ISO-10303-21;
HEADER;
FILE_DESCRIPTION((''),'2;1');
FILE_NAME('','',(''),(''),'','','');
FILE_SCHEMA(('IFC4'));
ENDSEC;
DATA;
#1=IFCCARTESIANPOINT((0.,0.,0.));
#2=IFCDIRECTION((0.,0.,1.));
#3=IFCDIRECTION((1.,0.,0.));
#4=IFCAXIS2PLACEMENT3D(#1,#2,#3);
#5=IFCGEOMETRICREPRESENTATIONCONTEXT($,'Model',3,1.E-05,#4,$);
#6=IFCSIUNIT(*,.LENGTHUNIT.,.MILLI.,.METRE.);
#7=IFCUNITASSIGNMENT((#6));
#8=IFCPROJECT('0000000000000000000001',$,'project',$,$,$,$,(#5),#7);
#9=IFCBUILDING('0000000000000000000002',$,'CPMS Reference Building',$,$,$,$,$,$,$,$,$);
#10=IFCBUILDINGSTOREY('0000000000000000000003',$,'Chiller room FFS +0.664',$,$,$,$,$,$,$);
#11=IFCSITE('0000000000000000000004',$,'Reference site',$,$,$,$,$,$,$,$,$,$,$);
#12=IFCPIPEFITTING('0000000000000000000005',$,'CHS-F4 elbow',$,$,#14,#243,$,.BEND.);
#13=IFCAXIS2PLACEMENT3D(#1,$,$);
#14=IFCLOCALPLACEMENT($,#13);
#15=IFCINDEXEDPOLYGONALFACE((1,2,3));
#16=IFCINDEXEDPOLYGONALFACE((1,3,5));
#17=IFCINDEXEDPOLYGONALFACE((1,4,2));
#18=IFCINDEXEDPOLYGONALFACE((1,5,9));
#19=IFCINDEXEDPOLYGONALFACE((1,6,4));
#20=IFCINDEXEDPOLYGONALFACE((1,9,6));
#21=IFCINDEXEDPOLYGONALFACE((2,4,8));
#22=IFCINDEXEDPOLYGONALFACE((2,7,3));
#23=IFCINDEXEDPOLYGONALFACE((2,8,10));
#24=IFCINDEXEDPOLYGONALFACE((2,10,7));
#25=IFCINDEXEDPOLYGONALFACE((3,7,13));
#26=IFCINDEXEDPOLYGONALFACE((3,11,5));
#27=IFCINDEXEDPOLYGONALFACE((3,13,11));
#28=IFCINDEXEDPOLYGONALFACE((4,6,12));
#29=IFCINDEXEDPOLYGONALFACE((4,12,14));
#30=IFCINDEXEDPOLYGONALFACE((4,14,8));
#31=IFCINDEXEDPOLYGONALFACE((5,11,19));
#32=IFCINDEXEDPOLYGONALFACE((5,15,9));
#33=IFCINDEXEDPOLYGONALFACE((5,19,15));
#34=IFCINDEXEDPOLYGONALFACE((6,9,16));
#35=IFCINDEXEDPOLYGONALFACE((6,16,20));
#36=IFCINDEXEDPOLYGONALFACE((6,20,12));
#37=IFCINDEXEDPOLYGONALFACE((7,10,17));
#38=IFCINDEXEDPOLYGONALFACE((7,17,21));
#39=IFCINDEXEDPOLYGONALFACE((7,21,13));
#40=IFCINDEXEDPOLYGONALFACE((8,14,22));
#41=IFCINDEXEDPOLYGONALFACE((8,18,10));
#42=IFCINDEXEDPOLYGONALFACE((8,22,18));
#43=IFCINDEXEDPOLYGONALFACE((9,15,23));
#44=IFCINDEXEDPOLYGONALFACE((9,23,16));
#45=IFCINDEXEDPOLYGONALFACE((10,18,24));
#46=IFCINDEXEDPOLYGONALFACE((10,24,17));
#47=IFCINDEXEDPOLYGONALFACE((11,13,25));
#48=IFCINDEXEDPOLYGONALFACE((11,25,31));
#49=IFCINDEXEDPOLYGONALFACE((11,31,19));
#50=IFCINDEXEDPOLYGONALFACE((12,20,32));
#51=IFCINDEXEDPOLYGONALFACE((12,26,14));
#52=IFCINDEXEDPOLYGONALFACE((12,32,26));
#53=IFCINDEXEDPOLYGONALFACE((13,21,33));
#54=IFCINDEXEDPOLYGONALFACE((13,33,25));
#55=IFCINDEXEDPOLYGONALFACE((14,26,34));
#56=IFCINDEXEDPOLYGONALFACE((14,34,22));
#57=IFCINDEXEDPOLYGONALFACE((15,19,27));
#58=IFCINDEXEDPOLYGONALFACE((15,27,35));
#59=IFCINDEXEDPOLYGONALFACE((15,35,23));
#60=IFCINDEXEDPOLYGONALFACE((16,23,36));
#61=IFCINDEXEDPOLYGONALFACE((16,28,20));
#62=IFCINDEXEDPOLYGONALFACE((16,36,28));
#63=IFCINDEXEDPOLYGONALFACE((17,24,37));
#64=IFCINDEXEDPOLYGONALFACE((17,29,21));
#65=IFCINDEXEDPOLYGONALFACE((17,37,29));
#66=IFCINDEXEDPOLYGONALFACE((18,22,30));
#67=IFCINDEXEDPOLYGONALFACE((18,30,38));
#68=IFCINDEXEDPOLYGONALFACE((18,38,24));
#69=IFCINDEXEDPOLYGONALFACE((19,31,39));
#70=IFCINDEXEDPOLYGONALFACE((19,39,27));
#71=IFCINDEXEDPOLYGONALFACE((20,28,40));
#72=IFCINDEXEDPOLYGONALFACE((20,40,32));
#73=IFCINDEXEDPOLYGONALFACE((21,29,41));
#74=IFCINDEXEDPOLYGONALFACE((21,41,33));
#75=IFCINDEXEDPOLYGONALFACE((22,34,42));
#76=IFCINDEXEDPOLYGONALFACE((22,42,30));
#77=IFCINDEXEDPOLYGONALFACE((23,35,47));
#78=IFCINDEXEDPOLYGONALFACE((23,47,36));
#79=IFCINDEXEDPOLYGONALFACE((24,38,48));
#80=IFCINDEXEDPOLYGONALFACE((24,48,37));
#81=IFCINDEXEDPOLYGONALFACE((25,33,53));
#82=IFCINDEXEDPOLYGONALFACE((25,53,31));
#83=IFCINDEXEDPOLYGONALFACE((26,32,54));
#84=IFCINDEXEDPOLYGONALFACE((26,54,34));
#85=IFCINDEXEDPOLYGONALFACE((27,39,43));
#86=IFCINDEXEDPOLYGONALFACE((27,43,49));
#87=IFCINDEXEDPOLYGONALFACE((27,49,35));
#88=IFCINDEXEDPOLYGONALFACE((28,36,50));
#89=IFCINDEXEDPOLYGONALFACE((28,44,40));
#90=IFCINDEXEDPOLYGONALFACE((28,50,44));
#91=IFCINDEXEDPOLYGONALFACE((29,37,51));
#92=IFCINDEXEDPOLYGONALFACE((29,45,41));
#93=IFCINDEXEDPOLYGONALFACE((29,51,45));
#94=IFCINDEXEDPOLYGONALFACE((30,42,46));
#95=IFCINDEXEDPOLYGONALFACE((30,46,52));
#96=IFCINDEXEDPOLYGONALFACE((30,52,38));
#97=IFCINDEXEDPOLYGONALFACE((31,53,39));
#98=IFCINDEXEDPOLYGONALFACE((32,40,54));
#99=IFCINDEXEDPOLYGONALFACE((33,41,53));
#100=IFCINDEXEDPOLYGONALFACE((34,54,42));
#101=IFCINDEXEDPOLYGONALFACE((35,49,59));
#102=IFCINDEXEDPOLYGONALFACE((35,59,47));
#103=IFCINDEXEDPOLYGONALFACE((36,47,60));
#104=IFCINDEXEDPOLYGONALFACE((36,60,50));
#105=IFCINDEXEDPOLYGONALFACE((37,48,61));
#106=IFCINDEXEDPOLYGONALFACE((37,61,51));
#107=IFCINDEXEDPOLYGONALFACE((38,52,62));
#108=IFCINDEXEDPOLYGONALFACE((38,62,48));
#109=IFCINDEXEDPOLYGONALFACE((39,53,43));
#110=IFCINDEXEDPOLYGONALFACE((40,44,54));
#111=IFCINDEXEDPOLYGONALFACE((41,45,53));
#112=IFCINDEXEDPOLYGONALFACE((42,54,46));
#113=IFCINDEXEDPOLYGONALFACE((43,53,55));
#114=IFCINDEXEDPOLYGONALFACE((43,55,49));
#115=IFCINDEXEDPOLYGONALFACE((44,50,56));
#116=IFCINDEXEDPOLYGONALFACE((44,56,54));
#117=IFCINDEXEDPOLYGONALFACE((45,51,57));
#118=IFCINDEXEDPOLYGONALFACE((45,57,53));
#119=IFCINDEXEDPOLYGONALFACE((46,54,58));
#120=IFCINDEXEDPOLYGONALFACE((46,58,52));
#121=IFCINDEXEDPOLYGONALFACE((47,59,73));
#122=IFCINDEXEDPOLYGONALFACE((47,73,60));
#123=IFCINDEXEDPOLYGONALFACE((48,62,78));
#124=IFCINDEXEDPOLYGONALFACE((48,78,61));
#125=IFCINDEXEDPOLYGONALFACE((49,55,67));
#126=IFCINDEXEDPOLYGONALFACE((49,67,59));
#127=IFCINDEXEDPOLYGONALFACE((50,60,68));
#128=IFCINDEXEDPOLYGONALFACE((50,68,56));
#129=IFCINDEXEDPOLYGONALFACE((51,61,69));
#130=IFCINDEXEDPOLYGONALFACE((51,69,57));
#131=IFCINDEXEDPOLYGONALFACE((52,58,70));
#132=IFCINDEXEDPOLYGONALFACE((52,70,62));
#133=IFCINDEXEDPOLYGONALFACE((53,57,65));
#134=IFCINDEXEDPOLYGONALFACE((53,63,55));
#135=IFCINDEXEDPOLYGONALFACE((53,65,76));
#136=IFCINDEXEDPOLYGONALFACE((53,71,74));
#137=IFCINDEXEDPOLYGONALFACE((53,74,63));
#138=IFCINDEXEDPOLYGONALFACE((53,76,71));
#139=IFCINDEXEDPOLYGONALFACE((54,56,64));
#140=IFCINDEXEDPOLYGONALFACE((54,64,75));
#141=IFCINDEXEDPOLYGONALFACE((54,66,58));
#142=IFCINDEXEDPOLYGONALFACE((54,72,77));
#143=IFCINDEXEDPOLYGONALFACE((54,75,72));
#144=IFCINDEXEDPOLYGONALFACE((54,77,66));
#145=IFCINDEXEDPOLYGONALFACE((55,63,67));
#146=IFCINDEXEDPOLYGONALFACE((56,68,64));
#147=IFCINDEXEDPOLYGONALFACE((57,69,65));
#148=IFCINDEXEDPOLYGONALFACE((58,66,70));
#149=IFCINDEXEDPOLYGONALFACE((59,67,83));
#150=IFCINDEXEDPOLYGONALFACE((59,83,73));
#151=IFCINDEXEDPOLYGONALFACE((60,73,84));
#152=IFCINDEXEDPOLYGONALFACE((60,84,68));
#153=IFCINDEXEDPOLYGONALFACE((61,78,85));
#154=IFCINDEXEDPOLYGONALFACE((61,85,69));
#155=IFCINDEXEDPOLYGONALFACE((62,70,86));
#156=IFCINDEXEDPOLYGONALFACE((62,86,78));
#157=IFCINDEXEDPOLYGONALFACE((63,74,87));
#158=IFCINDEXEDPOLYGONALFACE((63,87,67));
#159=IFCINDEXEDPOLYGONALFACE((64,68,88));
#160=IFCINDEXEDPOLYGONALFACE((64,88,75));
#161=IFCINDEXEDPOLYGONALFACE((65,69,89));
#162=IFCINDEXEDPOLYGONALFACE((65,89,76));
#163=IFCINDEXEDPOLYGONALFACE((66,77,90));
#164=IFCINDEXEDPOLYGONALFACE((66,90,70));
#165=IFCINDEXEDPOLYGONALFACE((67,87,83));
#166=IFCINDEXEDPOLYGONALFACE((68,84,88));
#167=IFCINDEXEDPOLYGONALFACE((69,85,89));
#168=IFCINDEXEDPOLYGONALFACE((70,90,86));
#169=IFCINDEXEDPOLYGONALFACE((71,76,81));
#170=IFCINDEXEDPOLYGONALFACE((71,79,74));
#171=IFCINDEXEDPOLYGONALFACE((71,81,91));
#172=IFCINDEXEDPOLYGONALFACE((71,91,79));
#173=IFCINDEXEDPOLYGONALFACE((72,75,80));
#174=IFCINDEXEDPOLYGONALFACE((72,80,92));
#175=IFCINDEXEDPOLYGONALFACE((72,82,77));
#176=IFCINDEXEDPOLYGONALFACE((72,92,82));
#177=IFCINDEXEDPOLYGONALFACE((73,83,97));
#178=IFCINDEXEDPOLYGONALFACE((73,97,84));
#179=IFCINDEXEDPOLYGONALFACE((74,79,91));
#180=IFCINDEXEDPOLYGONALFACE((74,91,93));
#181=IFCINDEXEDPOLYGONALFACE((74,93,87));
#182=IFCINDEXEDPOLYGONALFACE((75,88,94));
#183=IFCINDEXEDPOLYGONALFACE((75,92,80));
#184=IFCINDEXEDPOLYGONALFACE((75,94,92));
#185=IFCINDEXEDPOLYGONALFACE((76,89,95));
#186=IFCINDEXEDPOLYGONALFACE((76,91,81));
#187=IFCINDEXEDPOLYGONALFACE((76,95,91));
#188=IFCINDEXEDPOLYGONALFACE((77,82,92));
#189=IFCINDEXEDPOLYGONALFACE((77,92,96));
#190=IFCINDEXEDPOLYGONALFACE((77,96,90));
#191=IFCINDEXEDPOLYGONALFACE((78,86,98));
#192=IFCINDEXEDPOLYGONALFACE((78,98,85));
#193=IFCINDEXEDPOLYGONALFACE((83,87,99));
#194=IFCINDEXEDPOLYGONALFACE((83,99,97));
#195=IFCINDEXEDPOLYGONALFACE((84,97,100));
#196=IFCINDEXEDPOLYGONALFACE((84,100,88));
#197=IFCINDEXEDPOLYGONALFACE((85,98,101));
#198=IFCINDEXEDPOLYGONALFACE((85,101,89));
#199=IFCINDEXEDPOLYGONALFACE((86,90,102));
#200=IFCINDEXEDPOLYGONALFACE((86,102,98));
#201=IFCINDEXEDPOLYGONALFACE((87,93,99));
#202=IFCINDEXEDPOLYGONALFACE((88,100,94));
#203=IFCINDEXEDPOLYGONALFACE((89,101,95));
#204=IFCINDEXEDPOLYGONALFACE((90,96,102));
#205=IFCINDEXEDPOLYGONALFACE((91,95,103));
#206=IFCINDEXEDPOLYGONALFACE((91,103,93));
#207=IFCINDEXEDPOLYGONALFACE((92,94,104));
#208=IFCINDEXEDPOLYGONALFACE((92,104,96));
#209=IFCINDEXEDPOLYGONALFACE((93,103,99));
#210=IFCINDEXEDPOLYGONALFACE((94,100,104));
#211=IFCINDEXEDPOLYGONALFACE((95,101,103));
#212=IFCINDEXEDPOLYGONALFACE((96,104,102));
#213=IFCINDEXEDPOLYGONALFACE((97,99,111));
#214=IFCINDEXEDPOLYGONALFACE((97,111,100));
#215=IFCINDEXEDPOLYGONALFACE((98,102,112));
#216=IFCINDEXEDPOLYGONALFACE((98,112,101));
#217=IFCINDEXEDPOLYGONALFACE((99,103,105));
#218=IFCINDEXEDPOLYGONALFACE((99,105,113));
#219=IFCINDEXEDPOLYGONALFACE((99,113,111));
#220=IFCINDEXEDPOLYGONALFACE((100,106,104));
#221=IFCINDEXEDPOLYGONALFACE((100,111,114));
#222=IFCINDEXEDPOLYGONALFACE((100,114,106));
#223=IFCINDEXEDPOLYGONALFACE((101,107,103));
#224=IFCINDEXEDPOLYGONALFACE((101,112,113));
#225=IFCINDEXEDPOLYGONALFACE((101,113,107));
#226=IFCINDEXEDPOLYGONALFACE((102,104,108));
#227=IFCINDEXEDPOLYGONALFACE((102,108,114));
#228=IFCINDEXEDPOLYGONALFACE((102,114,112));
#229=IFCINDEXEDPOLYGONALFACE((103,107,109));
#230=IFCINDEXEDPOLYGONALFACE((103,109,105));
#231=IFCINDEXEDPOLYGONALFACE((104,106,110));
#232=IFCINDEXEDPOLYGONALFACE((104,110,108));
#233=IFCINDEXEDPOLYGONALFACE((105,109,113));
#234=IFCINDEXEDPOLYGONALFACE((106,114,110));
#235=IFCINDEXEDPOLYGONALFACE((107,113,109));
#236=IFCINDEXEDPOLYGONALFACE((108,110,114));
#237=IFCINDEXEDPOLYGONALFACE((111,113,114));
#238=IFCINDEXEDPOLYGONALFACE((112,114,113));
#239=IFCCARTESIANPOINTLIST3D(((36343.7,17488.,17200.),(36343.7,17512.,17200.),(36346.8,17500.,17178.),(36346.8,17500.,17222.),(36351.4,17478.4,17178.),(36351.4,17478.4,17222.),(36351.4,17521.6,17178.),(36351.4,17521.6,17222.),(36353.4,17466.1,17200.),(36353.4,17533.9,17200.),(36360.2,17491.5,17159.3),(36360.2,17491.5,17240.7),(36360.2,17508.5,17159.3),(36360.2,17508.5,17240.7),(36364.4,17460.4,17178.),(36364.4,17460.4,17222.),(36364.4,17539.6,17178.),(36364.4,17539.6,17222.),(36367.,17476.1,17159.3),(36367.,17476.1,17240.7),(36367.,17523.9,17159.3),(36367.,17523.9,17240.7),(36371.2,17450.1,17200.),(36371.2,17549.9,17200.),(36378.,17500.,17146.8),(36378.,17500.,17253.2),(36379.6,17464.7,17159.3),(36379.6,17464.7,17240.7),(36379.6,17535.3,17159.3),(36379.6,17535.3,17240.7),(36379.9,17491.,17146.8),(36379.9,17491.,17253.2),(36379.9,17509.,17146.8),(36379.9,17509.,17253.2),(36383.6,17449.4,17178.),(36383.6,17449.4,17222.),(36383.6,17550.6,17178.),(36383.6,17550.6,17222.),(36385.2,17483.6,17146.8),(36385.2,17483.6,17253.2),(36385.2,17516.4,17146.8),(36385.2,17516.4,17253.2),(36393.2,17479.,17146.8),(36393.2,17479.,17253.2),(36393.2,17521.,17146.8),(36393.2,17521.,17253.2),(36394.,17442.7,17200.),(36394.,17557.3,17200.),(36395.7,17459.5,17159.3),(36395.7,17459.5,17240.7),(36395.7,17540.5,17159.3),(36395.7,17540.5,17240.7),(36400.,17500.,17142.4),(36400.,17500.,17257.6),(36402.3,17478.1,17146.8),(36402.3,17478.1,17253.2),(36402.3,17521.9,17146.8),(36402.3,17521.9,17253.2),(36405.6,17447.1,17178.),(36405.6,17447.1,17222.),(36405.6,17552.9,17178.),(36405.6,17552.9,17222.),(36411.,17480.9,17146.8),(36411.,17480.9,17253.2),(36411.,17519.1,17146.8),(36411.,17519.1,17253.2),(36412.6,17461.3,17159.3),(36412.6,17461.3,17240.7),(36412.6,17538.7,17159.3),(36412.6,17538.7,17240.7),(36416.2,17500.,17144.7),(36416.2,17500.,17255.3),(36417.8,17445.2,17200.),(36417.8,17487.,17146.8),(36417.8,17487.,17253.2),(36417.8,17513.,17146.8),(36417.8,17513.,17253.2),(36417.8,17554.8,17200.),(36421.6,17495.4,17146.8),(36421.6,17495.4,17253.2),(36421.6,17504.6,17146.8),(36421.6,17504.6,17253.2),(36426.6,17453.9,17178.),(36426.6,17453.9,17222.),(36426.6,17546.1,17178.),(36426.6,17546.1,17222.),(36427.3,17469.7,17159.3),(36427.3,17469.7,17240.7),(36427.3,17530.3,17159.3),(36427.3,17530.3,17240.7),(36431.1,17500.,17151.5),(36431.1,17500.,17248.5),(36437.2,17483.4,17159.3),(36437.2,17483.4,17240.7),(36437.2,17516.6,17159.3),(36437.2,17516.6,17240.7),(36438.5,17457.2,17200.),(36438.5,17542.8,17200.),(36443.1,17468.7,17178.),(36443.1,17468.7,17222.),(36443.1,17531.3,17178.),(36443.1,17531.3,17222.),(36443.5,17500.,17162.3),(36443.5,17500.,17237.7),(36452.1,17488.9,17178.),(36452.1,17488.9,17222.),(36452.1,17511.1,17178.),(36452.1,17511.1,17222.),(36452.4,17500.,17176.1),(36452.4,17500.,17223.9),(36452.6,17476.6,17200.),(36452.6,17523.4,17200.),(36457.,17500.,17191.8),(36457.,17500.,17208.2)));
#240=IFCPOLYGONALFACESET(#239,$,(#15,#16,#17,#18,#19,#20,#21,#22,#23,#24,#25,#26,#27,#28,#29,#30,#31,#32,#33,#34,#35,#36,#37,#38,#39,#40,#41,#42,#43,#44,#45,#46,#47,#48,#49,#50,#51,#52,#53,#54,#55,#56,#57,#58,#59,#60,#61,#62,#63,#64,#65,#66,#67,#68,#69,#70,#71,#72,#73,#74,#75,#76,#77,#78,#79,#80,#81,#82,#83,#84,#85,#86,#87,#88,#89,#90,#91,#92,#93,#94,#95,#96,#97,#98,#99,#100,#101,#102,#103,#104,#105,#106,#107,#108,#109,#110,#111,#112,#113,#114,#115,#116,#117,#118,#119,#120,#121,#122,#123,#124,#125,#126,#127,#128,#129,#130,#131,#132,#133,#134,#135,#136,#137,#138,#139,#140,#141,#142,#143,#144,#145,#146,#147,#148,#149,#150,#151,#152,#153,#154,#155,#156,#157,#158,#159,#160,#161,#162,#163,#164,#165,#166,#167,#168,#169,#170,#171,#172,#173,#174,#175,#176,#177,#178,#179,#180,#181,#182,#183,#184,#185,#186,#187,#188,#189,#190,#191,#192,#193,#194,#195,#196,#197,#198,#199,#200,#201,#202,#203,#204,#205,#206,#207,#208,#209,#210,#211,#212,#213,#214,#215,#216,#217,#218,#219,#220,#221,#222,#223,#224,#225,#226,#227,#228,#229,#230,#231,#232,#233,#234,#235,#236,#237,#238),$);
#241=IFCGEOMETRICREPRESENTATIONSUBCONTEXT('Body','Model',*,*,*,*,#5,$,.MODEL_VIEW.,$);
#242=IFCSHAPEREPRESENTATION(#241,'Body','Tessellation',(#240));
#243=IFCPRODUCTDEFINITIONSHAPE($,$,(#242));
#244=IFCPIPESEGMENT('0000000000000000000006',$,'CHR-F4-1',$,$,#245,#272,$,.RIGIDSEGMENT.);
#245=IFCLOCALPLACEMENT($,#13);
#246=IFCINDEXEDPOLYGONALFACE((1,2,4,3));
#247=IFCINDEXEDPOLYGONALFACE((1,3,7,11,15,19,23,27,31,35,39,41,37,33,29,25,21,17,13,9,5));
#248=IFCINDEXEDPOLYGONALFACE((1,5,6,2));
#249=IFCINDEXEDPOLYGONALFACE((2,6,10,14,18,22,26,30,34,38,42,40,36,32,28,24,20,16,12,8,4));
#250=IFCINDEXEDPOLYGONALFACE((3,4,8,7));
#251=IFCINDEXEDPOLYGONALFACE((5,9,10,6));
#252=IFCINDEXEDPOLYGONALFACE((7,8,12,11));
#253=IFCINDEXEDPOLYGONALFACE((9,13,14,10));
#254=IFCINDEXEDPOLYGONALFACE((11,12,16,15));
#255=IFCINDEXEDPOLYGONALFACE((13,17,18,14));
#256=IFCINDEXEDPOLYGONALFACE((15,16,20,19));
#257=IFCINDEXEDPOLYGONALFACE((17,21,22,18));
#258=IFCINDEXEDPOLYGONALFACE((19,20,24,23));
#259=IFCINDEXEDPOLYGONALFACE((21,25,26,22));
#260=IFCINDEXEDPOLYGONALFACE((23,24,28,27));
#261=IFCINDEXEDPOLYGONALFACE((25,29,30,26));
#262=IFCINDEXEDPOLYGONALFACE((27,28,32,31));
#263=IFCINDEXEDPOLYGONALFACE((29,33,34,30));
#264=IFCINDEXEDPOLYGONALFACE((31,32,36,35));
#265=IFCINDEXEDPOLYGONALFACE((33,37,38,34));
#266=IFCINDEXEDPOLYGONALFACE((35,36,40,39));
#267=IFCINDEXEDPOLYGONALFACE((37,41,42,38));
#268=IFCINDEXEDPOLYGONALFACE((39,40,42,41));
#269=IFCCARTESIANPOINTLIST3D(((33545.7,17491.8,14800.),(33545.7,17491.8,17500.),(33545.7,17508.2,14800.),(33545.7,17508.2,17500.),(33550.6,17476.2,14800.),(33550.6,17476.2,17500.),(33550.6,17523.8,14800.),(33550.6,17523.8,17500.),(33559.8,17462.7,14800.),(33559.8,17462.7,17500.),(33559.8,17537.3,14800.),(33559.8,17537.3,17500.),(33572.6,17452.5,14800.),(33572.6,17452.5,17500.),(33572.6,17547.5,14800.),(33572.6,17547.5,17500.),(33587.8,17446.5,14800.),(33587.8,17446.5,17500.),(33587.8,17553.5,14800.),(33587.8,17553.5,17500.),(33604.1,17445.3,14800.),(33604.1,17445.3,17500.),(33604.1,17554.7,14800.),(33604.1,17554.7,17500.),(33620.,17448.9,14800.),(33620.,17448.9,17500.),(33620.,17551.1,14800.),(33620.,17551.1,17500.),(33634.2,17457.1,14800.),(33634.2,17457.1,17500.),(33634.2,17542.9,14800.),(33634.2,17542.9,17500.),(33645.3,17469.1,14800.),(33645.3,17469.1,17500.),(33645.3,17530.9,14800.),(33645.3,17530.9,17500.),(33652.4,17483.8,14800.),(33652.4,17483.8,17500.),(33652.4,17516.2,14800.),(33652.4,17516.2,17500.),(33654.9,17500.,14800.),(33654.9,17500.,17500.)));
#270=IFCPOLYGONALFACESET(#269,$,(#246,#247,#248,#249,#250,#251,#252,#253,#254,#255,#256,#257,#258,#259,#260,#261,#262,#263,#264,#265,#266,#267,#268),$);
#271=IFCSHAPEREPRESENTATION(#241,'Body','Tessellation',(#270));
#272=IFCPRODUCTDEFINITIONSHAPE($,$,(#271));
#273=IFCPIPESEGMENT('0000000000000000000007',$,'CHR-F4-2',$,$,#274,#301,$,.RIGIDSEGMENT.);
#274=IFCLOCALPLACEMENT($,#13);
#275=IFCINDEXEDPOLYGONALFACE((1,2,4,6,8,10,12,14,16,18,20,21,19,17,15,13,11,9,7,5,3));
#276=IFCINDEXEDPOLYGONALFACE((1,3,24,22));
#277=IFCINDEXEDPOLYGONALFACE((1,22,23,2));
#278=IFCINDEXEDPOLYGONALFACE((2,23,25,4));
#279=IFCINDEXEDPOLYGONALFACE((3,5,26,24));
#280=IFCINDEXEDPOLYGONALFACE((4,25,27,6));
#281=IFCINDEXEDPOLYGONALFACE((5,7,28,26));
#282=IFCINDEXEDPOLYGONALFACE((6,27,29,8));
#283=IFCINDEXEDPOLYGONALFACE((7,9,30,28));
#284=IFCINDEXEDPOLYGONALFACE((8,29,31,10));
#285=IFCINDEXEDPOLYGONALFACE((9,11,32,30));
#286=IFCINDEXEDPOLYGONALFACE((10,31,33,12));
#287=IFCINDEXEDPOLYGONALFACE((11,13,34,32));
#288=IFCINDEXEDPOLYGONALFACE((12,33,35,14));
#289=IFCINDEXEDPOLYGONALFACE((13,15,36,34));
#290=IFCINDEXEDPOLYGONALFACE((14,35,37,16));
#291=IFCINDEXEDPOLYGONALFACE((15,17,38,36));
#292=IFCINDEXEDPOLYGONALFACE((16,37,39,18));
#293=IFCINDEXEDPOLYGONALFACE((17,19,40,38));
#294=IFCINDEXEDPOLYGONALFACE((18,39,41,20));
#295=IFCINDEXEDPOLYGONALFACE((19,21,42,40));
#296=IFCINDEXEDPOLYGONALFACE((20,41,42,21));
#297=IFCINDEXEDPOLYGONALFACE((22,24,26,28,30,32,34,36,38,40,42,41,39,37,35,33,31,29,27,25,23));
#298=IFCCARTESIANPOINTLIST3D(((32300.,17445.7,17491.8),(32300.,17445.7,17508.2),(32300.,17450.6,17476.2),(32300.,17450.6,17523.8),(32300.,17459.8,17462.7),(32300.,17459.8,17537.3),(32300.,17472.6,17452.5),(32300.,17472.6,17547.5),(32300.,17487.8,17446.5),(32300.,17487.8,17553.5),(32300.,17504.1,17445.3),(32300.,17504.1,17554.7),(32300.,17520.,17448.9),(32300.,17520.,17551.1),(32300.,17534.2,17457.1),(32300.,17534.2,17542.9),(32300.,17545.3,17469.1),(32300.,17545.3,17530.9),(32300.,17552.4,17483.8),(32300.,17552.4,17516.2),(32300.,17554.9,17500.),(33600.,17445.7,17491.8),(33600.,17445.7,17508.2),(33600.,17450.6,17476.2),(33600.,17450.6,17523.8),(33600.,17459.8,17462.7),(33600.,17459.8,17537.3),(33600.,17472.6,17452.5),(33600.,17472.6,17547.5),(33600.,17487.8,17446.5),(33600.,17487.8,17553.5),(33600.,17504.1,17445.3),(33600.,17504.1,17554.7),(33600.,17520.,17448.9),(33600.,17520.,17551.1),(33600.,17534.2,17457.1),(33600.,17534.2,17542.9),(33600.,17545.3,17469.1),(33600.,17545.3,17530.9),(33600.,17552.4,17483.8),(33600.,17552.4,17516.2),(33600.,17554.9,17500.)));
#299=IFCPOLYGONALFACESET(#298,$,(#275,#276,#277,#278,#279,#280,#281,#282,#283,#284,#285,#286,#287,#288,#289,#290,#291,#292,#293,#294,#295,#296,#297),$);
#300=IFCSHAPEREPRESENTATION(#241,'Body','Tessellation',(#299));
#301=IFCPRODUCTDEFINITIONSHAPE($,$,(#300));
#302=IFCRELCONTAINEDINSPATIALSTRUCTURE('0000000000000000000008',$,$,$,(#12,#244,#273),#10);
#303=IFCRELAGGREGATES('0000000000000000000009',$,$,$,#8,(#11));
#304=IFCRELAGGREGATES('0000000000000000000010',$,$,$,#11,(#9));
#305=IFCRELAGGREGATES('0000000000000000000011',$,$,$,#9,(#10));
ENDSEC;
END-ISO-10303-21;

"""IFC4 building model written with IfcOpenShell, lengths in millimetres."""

from ifc_helpers import new_model, entity, si_unit, frame, origin_with_axes, origin_2d, place, context, subcontext, project, spatial, circle_curve, outline, extrude, element, save


model = new_model("IFC4")

# Units and contexts
model_context = context("Model", 3, precision=1e-05, world=origin_with_axes())
body_context = subcontext(model_context, "Body", "Model", "MODEL_VIEW")
ifc_project = project(units=[si_unit("LENGTHUNIT", "METRE", prefix="MILLI")], contexts=[model_context])

# Site, building, storey
site = spatial("IfcSite", under=ifc_project, Name="Reference site")
building = spatial("IfcBuilding", under=site, Name="CPMS Reference Building")
storey = spatial("IfcBuildingStorey", under=building, Name="Chiller room FFS +0.664")

# Pipe fitting
pipe_fitting_1_placement = place(None, origin_with_axes())
element("IfcPipeFitting", 1, at=pipe_fitting_1_placement, inside=storey, Name="CHS-F4 elbow", PredefinedType="BEND", context=body_context, shape_type="CSG", body=[
    entity("IfcSphere", entity("IfcAxis2Placement3D", entity("IfcCartesianPoint", [36400.0, 17500.0, 17200.0]), entity("IfcDirection", [0.0, 0.0, 1.0]), entity("IfcDirection", [1.0, 0.0, 0.0])), 57.6),
])

# Pipe segments
pipe_segment_1_placement = place(None, origin_with_axes())
element("IfcPipeSegment", 2, at=pipe_segment_1_placement, inside=storey, Name="CHR-F4-1", PredefinedType="RIGIDSEGMENT", context=body_context, shape_type="SweptSolid", body=[
    extrude(outline(circle_curve(origin_2d(), 54.9)), frame((33600.0, 17500.0, 14800.0), z_axis=(0.0, 0.0, 1.0), x_axis=(1.0, 0.0, 0.0)), (0.0, 0.0, 1.0), 2700.0),
])
pipe_segment_2_placement = place(None, origin_with_axes())
element("IfcPipeSegment", 3, at=pipe_segment_2_placement, inside=storey, Name="CHR-F4-2", PredefinedType="RIGIDSEGMENT", context=body_context, shape_type="SweptSolid", body=[
    extrude(outline(circle_curve(origin_2d(), 54.9)), frame((33600.0, 17500.0, 17500.0), z_axis=(-1.0, 0.0, 0.0), x_axis=(0.0, 1.0, 0.0)), (0.0, 0.0, 1.0), 1300.0),
])

save(model, "model.ifc")
